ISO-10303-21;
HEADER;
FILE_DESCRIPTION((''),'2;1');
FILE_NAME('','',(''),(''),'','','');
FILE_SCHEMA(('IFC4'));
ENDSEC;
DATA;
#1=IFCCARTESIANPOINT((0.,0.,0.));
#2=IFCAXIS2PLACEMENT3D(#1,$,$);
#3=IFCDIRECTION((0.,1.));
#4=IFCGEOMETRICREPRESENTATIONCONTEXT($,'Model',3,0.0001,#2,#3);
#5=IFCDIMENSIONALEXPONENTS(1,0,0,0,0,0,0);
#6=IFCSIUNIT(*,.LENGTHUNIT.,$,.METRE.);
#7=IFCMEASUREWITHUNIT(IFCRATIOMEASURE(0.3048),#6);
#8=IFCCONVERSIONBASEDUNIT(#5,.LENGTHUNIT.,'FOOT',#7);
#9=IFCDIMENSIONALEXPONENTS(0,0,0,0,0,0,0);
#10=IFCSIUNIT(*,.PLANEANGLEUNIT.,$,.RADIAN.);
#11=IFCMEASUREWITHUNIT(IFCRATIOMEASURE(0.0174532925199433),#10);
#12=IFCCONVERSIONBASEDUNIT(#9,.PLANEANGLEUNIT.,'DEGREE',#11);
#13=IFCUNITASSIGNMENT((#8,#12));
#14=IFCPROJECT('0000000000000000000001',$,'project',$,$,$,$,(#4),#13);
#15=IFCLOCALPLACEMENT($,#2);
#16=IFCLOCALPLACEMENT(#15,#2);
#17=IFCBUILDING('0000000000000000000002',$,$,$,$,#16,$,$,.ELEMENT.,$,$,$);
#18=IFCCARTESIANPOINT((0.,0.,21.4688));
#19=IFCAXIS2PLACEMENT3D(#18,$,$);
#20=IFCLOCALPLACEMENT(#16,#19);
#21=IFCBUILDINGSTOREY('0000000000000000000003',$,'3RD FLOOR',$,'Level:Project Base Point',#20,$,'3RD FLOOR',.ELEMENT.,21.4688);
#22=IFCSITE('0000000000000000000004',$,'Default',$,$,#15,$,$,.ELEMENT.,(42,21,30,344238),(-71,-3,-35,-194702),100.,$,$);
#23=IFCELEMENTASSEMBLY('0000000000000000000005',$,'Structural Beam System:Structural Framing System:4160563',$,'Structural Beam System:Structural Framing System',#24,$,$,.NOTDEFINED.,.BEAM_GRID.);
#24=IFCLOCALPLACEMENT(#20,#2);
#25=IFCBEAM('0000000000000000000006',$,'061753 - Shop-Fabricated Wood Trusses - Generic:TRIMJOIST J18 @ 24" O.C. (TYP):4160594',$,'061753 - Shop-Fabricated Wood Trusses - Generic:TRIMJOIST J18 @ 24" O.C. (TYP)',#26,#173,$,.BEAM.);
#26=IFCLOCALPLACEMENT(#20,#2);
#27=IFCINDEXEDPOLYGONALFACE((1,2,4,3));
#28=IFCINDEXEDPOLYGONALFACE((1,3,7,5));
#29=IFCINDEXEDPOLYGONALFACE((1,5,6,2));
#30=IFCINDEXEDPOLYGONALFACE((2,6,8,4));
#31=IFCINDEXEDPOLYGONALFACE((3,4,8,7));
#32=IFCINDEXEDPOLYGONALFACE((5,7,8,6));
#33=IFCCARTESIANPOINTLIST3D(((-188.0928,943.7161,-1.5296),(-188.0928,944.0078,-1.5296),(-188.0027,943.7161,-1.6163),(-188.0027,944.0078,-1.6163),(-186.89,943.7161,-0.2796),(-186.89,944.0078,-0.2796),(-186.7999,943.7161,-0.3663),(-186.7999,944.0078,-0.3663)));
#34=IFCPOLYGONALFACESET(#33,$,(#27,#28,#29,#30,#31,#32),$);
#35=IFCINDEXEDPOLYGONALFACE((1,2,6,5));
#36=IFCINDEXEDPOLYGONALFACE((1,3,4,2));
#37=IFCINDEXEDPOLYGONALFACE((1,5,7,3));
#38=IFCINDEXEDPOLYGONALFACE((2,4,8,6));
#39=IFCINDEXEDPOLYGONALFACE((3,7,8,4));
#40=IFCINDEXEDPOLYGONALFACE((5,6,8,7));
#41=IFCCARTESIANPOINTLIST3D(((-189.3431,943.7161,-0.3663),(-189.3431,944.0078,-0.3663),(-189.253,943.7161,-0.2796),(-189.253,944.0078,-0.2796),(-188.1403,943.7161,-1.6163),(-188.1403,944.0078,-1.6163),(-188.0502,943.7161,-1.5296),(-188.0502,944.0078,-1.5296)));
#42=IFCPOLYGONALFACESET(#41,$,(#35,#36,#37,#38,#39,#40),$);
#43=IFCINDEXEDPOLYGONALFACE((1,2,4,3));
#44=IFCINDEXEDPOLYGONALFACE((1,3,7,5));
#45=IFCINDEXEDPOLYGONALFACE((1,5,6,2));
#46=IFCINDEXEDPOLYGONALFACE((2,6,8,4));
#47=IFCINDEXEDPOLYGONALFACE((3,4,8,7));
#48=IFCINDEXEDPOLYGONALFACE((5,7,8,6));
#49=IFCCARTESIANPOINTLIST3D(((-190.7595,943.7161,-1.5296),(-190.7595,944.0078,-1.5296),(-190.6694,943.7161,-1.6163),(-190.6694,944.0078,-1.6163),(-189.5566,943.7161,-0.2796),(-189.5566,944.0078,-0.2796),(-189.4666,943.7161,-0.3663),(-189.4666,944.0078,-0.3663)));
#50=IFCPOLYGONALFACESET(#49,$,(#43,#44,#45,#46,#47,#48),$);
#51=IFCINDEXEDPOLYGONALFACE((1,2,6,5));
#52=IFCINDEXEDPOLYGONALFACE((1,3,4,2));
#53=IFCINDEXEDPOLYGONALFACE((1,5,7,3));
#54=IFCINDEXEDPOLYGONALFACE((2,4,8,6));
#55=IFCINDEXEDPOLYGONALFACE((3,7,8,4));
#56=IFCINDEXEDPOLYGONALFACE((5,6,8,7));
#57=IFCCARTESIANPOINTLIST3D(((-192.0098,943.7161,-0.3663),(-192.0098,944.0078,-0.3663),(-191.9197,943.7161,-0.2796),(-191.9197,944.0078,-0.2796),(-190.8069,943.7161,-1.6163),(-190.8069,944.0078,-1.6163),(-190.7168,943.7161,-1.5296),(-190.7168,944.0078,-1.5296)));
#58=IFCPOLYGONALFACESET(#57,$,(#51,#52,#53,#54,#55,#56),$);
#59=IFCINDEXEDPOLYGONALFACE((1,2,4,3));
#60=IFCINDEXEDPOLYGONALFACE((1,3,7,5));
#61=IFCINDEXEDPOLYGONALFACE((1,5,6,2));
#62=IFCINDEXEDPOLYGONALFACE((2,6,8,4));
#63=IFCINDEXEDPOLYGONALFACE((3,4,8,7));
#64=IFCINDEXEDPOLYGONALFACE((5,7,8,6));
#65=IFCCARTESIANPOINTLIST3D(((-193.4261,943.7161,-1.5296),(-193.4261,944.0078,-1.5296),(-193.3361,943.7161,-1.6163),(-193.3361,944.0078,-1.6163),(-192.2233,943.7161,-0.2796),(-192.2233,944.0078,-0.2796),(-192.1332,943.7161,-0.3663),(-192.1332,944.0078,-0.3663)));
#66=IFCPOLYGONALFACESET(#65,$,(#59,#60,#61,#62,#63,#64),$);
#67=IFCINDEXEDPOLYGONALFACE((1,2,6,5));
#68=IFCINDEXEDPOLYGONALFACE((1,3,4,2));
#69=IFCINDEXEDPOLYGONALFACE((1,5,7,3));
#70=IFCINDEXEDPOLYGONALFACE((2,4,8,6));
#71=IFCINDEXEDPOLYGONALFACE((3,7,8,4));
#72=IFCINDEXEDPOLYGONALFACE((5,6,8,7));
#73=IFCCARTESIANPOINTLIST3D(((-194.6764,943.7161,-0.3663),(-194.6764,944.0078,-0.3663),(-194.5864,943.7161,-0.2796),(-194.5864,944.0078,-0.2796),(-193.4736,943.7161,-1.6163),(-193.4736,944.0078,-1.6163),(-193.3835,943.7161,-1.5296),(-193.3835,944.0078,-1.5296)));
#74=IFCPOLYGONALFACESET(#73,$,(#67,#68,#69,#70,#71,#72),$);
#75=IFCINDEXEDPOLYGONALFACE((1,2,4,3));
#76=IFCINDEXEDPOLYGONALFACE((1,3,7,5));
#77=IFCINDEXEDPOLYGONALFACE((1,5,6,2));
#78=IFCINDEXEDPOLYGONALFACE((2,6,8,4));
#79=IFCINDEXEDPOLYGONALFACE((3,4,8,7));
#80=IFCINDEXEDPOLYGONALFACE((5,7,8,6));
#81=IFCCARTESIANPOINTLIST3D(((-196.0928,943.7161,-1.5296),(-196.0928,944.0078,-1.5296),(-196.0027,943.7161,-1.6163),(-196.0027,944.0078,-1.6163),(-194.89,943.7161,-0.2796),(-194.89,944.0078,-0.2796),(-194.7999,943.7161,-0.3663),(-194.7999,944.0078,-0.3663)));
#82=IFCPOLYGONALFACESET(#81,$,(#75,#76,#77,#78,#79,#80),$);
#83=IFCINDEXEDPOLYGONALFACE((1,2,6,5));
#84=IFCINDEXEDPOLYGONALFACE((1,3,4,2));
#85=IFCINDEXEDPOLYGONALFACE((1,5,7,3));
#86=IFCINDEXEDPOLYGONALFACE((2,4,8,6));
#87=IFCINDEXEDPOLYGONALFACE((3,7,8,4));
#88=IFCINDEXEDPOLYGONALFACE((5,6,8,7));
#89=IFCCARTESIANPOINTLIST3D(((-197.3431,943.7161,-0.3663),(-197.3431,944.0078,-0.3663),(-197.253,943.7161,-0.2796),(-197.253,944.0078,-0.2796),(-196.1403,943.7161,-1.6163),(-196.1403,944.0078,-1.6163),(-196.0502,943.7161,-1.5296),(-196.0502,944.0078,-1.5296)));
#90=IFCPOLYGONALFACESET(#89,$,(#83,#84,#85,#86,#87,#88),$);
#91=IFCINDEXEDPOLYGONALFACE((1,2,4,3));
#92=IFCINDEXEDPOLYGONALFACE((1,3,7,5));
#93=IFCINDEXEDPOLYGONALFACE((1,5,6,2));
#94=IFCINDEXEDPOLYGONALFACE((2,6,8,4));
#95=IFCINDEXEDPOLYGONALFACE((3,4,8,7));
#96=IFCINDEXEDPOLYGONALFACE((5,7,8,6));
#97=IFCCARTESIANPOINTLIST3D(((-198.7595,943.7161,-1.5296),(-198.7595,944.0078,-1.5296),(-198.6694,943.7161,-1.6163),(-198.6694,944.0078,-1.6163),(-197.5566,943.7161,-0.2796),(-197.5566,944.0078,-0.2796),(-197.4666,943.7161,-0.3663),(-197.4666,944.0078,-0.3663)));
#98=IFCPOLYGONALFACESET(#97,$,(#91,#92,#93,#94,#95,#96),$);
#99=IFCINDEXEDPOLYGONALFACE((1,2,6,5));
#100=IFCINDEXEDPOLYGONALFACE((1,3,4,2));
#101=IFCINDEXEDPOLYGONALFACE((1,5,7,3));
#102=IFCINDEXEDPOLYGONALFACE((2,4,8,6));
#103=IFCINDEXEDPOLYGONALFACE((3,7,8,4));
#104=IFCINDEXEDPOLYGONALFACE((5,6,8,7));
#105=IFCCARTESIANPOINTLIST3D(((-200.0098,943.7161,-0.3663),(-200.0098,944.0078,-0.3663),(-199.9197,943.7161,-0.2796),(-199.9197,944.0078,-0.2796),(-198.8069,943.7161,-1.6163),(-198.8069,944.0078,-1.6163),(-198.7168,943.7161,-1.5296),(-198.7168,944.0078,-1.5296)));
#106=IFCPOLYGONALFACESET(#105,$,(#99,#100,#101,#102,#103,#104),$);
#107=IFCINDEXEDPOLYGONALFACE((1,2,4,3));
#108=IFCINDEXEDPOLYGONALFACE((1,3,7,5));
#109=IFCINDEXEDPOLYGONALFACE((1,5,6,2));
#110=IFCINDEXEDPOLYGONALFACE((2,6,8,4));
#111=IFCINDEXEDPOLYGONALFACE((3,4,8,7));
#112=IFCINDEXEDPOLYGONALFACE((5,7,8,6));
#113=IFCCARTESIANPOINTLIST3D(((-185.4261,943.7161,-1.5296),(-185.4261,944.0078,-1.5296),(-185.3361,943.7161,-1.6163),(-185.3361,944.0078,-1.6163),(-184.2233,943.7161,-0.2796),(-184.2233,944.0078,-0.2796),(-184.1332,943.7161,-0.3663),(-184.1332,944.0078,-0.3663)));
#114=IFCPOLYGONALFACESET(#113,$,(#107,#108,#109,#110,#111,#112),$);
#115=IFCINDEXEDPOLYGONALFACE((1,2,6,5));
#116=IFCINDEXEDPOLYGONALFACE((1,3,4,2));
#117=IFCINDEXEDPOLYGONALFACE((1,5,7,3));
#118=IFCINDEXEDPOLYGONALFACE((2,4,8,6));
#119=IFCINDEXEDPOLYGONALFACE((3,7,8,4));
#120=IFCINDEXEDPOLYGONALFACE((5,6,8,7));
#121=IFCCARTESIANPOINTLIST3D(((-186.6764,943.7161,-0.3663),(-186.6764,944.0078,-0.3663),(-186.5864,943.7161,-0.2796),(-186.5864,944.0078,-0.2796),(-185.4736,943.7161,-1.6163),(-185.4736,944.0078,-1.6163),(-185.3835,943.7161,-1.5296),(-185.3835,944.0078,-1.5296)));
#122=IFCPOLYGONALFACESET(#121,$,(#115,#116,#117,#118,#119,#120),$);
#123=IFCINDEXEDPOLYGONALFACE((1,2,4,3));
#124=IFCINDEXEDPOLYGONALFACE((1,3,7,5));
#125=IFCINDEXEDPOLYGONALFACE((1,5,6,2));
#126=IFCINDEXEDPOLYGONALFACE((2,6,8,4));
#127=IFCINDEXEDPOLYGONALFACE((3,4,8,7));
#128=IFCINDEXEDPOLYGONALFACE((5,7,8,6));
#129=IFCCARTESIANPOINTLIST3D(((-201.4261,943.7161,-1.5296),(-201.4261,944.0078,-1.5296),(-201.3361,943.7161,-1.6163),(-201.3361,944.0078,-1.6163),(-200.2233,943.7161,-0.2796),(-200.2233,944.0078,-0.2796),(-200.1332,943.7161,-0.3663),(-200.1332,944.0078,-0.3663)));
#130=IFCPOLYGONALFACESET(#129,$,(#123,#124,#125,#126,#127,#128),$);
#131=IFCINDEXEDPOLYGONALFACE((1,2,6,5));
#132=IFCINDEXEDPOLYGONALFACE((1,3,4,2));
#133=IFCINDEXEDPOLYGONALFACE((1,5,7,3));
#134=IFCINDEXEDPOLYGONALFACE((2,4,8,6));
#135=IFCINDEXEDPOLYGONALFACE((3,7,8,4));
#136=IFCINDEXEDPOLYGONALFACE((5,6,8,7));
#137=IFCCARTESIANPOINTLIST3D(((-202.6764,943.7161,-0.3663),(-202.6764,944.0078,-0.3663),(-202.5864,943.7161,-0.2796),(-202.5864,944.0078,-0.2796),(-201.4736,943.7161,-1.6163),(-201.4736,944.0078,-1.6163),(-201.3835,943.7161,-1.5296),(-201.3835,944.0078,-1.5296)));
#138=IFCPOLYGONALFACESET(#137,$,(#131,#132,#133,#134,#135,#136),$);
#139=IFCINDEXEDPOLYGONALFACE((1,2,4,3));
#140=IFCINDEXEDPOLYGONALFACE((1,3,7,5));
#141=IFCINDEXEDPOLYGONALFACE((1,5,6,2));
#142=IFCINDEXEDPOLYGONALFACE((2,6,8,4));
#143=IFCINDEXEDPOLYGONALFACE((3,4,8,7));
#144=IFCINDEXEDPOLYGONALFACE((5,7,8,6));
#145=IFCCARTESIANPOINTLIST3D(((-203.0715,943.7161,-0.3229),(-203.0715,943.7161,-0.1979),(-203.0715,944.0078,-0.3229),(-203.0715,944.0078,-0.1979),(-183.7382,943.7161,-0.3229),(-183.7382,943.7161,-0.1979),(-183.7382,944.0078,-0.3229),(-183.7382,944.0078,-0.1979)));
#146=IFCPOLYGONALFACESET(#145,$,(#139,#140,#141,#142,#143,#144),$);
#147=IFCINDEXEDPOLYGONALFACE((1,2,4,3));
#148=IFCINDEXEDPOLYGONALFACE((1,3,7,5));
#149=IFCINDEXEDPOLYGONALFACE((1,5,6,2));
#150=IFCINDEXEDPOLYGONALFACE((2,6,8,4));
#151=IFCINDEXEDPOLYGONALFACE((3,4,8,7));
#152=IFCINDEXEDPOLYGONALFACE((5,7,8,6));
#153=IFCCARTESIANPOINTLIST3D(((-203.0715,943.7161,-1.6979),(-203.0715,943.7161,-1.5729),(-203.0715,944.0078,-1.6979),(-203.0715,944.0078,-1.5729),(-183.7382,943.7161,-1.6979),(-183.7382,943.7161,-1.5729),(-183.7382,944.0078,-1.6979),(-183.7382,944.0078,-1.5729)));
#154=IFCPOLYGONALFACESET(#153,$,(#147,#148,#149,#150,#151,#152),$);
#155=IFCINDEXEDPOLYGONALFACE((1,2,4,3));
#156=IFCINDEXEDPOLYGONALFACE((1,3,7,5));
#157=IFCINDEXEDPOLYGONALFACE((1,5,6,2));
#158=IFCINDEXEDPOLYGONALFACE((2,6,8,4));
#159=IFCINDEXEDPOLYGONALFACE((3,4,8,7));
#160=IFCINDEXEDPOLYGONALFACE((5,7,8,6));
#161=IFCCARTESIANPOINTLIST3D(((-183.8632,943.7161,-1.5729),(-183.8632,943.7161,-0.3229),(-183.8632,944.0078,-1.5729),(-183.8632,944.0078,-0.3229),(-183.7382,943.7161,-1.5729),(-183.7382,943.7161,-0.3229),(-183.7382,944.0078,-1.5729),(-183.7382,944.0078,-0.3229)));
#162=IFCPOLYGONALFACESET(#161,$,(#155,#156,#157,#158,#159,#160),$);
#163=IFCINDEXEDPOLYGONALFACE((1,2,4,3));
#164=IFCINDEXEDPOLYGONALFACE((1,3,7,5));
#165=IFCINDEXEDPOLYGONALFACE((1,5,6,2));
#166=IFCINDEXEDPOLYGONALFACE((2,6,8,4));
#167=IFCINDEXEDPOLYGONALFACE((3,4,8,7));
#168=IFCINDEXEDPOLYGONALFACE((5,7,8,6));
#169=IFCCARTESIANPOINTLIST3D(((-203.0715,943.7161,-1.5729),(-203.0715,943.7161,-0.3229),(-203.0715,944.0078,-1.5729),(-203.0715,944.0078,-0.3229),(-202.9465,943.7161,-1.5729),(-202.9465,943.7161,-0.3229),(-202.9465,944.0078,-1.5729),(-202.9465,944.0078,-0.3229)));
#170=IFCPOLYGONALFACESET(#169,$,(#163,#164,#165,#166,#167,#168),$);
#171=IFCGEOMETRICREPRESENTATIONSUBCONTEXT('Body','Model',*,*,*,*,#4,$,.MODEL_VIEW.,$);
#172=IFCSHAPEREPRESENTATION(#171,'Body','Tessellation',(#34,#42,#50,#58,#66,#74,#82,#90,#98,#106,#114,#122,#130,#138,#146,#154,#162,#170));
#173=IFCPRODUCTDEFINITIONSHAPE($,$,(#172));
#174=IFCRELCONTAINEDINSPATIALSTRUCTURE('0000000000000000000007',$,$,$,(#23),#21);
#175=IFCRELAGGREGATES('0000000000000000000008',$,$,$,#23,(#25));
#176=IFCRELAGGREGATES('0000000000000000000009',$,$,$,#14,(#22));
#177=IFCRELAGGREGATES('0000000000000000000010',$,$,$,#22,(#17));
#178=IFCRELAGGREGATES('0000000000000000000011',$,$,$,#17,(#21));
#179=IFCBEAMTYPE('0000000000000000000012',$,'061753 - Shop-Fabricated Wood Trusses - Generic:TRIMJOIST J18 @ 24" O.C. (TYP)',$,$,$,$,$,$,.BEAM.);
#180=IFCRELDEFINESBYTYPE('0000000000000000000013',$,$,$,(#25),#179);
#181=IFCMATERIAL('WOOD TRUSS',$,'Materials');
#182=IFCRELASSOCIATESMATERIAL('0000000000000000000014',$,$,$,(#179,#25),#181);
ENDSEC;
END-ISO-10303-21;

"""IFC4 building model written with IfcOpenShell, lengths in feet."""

from ifc_helpers import new_model, entity, si_unit, converted_unit, direction, frame, frame_2d, origin, origin_2d_with_axis, place, context, subcontext, project, spatial, rectangle, extrude, source, transform, mapped, material, material_profile, profile_set, profile_usage, type_object, type_shapes, element, aggregate, save


model = new_model("IFC4")

# Units and contexts
model_context = context("Model", 3, precision=0.0001, world=origin(), true_north=direction((0.0, 1.0)))
body_context = subcontext(model_context, "Body", "Model", "MODEL_VIEW")
ifc_project = project(units=[converted_unit("LENGTHUNIT", "FOOT", entity("IfcRatioMeasure", 0.3048), si_unit("LENGTHUNIT", "METRE"), dimensions=[1, 0, 0, 0, 0, 0, 0]), converted_unit("PLANEANGLEUNIT", "DEGREE", entity("IfcRatioMeasure", 0.0174532925199433), si_unit("PLANEANGLEUNIT", "RADIAN"), dimensions=[0, 0, 0, 0, 0, 0, 0])], contexts=[model_context])

# Site, building, storey
site_placement = place(None, origin())
site = spatial("IfcSite", under=ifc_project, at=site_placement, Name="Default", CompositionType="ELEMENT", RefLatitude=(42, 21, 30, 344238), RefLongitude=(-71, -3, -35, -194702), RefElevation=100.0)
building_placement = place(site_placement, origin())
building = spatial("IfcBuilding", under=site, at=building_placement, CompositionType="ELEMENT")
storey_placement = place(building_placement, frame((0.0, 0.0, 21.4688)))
storey = spatial("IfcBuildingStorey", under=building, at=storey_placement, Name="3RD FLOOR", ObjectType="Level:Project Base Point", LongName="3RD FLOOR", CompositionType="ELEMENT", Elevation=21.4688)

# Element assembly, beam
ifc_material = material(Name="WOOD TRUSS", Category="Materials")
ifc_material_profile_1 = material_profile(ifc_material, rectangle(XDim=1.7347, YDim=0.125, at=frame_2d((0.0, 0.0), x_axis=(1.0, 0.0))), Name="TRIMJOIST J18 @ 24\" O.C. (TYP)")
ifc_material_profile_2 = material_profile(ifc_material, rectangle(XDim=1.7347, YDim=0.125, at=frame_2d((0.0, 0.0), x_axis=(1.0, 0.0))), Name="TRIMJOIST J18 @ 24\" O.C. (TYP)")
ifc_material_profile_3 = material_profile(ifc_material, rectangle(XDim=1.7347, YDim=0.125, at=frame_2d((0.0, 0.0), x_axis=(1.0, 0.0))), Name="TRIMJOIST J18 @ 24\" O.C. (TYP)")
ifc_material_profile_4 = material_profile(ifc_material, rectangle(XDim=1.7347, YDim=0.125, at=frame_2d((0.0, 0.0), x_axis=(1.0, 0.0))), Name="TRIMJOIST J18 @ 24\" O.C. (TYP)")
ifc_material_profile_5 = material_profile(ifc_material, rectangle(XDim=1.7347, YDim=0.125, at=frame_2d((0.0, 0.0), x_axis=(1.0, 0.0))), Name="TRIMJOIST J18 @ 24\" O.C. (TYP)")
ifc_material_profile_6 = material_profile(ifc_material, rectangle(XDim=1.7347, YDim=0.125, at=frame_2d((0.0, 0.0), x_axis=(1.0, 0.0))), Name="TRIMJOIST J18 @ 24\" O.C. (TYP)")
ifc_material_profile_7 = material_profile(ifc_material, rectangle(XDim=1.7347, YDim=0.125, at=frame_2d((0.0, 0.0), x_axis=(1.0, 0.0))), Name="TRIMJOIST J18 @ 24\" O.C. (TYP)")
ifc_material_profile_8 = material_profile(ifc_material, rectangle(XDim=1.7347, YDim=0.125, at=frame_2d((0.0, 0.0), x_axis=(1.0, 0.0))), Name="TRIMJOIST J18 @ 24\" O.C. (TYP)")
ifc_material_profile_9 = material_profile(ifc_material, rectangle(XDim=1.7347, YDim=0.125, at=frame_2d((0.0, 0.0), x_axis=(1.0, 0.0))), Name="TRIMJOIST J18 @ 24\" O.C. (TYP)")
ifc_material_profile_10 = material_profile(ifc_material, rectangle(XDim=1.7347, YDim=0.125, at=origin_2d_with_axis()), Name="TRIMJOIST J18 @ 24\" O.C. (TYP)")
ifc_material_profile_11 = material_profile(ifc_material, rectangle(XDim=0.125, YDim=0.2917, at=origin_2d_with_axis()), Name="TRIMJOIST J18 @ 24\" O.C. (TYP)")
ifc_material_profile_12 = material_profile(ifc_material, rectangle(XDim=0.125, YDim=0.2917, at=origin_2d_with_axis()), Name="TRIMJOIST J18 @ 24\" O.C. (TYP)")
ifc_material_profile_13 = material_profile(ifc_material, rectangle(XDim=1.25, YDim=0.2917, at=origin_2d_with_axis()), Name="TRIMJOIST J18 @ 24\" O.C. (TYP)")
ifc_material_profile_14 = material_profile(ifc_material, rectangle(XDim=1.25, YDim=0.2917, at=origin_2d_with_axis()), Name="TRIMJOIST J18 @ 24\" O.C. (TYP)")
ifc_profile_set = profile_set([ifc_material_profile_1, ifc_material_profile_2, ifc_material_profile_3, ifc_material_profile_4, ifc_material_profile_5, ifc_material_profile_6, ifc_material_profile_7, ifc_material_profile_8, ifc_material_profile_9, ifc_material_profile_10, ifc_material_profile_11, ifc_material_profile_12, ifc_material_profile_13, ifc_material_profile_14], Name="TRIMJOIST J18 @ 24\" O.C. (TYP)")
beam_type_1 = type_object("IfcBeamType", Name="061753 - Shop-Fabricated Wood Trusses - Generic:TRIMJOIST J18 @ 24\" O.C. (TYP)", PredefinedType="BEAM", material=ifc_profile_set)
shared_shape_1 = source(origin(), body_context, "Body", "SweptSolid", [
    extrude(rectangle(XDim=1.7347, YDim=0.125, at=frame_2d((0.0, 0.0), x_axis=(1.0, 0.0))), frame((5.9585, -0.1458, 0.0), z_axis=(0.0, 1.0, 0.0), x_axis=(0.693383, 0.0, 0.720569)), (0.0, 0.0, 1.0), 0.2917),
    extrude(rectangle(XDim=1.7347, YDim=0.125, at=origin_2d_with_axis()), frame((4.7082, -0.1458, 0.0), z_axis=(0.0, 1.0, 0.0), x_axis=(0.693383, 0.0, -0.720569)), (0.0, 0.0, 1.0), 0.2917),
    extrude(rectangle(XDim=1.7347, YDim=0.125, at=frame_2d((0.0, 0.0), x_axis=(1.0, 0.0))), frame((3.2918, -0.1458, 0.0), z_axis=(0.0, 1.0, 0.0), x_axis=(0.693383, 0.0, 0.720569)), (0.0, 0.0, 1.0), 0.2917),
    extrude(rectangle(XDim=1.7347, YDim=0.125, at=frame_2d((0.0, 0.0), x_axis=(1.0, 0.0))), frame((2.0415, -0.1458, 0.0), z_axis=(0.0, 1.0, 0.0), x_axis=(0.693383, 0.0, -0.720569)), (0.0, 0.0, 1.0), 0.2917),
    extrude(rectangle(XDim=1.7347, YDim=0.125, at=frame_2d((0.0, 0.0), x_axis=(1.0, 0.0))), frame((0.6251, -0.1458, 0.0), z_axis=(0.0, 1.0, 0.0), x_axis=(0.693383, 0.0, 0.720569)), (0.0, 0.0, 1.0), 0.2917),
    extrude(rectangle(XDim=1.7347, YDim=0.125, at=frame_2d((0.0, 0.0), x_axis=(1.0, 0.0))), frame((-0.6251, -0.1458, 0.0), z_axis=(0.0, 1.0, 0.0), x_axis=(0.693383, 0.0, -0.720569)), (0.0, 0.0, 1.0), 0.2917),
    extrude(rectangle(XDim=1.7347, YDim=0.125, at=frame_2d((0.0, 0.0), x_axis=(1.0, 0.0))), frame((-2.0415, -0.1458, 0.0), z_axis=(0.0, 1.0, 0.0), x_axis=(0.693383, 0.0, 0.720569)), (0.0, 0.0, 1.0), 0.2917),
    extrude(rectangle(XDim=1.7347, YDim=0.125, at=origin_2d_with_axis()), frame((-3.2918, -0.1458, 0.0), z_axis=(0.0, 1.0, 0.0), x_axis=(0.693383, 0.0, -0.720569)), (0.0, 0.0, 1.0), 0.2917),
    extrude(rectangle(XDim=1.7347, YDim=0.125, at=frame_2d((0.0, 0.0), x_axis=(1.0, 0.0))), frame((-4.7082, -0.1458, 0.0), z_axis=(0.0, 1.0, 0.0), x_axis=(0.693383, 0.0, 0.720569)), (0.0, 0.0, 1.0), 0.2917),
    extrude(rectangle(XDim=1.7347, YDim=0.125, at=frame_2d((0.0, 0.0), x_axis=(1.0, 0.0))), frame((-5.9585, -0.1458, 0.0), z_axis=(0.0, 1.0, 0.0), x_axis=(0.693383, 0.0, -0.720569)), (0.0, 0.0, 1.0), 0.2917),
    extrude(rectangle(XDim=1.7347, YDim=0.125, at=frame_2d((0.0, 0.0), x_axis=(1.0, 0.0))), frame((8.6251, -0.1458, 0.0), z_axis=(0.0, 1.0, 0.0), x_axis=(0.693383, 0.0, 0.720569)), (0.0, 0.0, 1.0), 0.2917),
    extrude(rectangle(XDim=1.7347, YDim=0.125, at=origin_2d_with_axis()), frame((7.3749, -0.1458, 0.0), z_axis=(0.0, 1.0, 0.0), x_axis=(0.693383, 0.0, -0.720569)), (0.0, 0.0, 1.0), 0.2917),
    extrude(rectangle(XDim=1.7347, YDim=0.125, at=frame_2d((0.0, 0.0), x_axis=(1.0, 0.0))), frame((-7.3749, -0.1458, 0.0), z_axis=(0.0, 1.0, 0.0), x_axis=(0.693383, 0.0, 0.720569)), (0.0, 0.0, 1.0), 0.2917),
    extrude(rectangle(XDim=1.7347, YDim=0.125, at=origin_2d_with_axis()), frame((-8.6251, -0.1458, 0.0), z_axis=(0.0, 1.0, 0.0), x_axis=(0.693383, 0.0, -0.720569)), (0.0, 0.0, 1.0), 0.2917),
    extrude(rectangle(XDim=0.125, YDim=0.2917, at=origin_2d_with_axis()), frame((-9.6667, 0.0, 0.6875), z_axis=(1.0, 0.0, 0.0), x_axis=(0.0, 0.0, -1.0)), (0.0, 0.0, 1.0), 19.3333),
    extrude(rectangle(XDim=0.125, YDim=0.2917, at=origin_2d_with_axis()), frame((-9.6667, 0.0, -0.6875), z_axis=(1.0, 0.0, 0.0), x_axis=(0.0, 0.0, -1.0)), (0.0, 0.0, 1.0), 19.3333),
    extrude(rectangle(XDim=1.25, YDim=0.2917, at=origin_2d_with_axis()), frame((9.5417, 0.0, 0.0), z_axis=(1.0, 0.0, 0.0), x_axis=(0.0, 0.0, -1.0)), (0.0, 0.0, 1.0), 0.125),
    extrude(rectangle(XDim=1.25, YDim=0.2917, at=origin_2d_with_axis()), frame((-9.6667, 0.0, 0.0), z_axis=(1.0, 0.0, 0.0), x_axis=(0.0, 0.0, -1.0)), (0.0, 0.0, 1.0), 0.125),
])
type_shapes(beam_type_1, [shared_shape_1])
assembly_1_placement = place(storey_placement, origin())
assembly_1 = element("IfcElementAssembly", 1, at=assembly_1_placement, inside=storey, Name="Structural Beam System:Structural Framing System:4160563", ObjectType="Structural Beam System:Structural Framing System", AssemblyPlace="NOTDEFINED", PredefinedType="BEAM_GRID")
ifc_profile_usage_1 = profile_usage(ifc_profile_set, cardinal=8)
beam_1_placement = place(assembly_1_placement, frame((-193.4048, 943.8619, -0.9479)))
beam_1 = element("IfcBeam", 2, at=beam_1_placement, type_object=beam_type_1, material=ifc_profile_usage_1, Name="061753 - Shop-Fabricated Wood Trusses - Generic:TRIMJOIST J18 @ 24\" O.C. (TYP):4160594", ObjectType="061753 - Shop-Fabricated Wood Trusses - Generic:TRIMJOIST J18 @ 24\" O.C. (TYP)", PredefinedType="BEAM", context=body_context, shape_type="MappedRepresentation", body=[
    mapped(shared_shape_1, transform((0.0, 0.0, 0.0), scale=1.0)),
])
aggregate(assembly_1, [beam_1])

save(model, "model.ifc")
